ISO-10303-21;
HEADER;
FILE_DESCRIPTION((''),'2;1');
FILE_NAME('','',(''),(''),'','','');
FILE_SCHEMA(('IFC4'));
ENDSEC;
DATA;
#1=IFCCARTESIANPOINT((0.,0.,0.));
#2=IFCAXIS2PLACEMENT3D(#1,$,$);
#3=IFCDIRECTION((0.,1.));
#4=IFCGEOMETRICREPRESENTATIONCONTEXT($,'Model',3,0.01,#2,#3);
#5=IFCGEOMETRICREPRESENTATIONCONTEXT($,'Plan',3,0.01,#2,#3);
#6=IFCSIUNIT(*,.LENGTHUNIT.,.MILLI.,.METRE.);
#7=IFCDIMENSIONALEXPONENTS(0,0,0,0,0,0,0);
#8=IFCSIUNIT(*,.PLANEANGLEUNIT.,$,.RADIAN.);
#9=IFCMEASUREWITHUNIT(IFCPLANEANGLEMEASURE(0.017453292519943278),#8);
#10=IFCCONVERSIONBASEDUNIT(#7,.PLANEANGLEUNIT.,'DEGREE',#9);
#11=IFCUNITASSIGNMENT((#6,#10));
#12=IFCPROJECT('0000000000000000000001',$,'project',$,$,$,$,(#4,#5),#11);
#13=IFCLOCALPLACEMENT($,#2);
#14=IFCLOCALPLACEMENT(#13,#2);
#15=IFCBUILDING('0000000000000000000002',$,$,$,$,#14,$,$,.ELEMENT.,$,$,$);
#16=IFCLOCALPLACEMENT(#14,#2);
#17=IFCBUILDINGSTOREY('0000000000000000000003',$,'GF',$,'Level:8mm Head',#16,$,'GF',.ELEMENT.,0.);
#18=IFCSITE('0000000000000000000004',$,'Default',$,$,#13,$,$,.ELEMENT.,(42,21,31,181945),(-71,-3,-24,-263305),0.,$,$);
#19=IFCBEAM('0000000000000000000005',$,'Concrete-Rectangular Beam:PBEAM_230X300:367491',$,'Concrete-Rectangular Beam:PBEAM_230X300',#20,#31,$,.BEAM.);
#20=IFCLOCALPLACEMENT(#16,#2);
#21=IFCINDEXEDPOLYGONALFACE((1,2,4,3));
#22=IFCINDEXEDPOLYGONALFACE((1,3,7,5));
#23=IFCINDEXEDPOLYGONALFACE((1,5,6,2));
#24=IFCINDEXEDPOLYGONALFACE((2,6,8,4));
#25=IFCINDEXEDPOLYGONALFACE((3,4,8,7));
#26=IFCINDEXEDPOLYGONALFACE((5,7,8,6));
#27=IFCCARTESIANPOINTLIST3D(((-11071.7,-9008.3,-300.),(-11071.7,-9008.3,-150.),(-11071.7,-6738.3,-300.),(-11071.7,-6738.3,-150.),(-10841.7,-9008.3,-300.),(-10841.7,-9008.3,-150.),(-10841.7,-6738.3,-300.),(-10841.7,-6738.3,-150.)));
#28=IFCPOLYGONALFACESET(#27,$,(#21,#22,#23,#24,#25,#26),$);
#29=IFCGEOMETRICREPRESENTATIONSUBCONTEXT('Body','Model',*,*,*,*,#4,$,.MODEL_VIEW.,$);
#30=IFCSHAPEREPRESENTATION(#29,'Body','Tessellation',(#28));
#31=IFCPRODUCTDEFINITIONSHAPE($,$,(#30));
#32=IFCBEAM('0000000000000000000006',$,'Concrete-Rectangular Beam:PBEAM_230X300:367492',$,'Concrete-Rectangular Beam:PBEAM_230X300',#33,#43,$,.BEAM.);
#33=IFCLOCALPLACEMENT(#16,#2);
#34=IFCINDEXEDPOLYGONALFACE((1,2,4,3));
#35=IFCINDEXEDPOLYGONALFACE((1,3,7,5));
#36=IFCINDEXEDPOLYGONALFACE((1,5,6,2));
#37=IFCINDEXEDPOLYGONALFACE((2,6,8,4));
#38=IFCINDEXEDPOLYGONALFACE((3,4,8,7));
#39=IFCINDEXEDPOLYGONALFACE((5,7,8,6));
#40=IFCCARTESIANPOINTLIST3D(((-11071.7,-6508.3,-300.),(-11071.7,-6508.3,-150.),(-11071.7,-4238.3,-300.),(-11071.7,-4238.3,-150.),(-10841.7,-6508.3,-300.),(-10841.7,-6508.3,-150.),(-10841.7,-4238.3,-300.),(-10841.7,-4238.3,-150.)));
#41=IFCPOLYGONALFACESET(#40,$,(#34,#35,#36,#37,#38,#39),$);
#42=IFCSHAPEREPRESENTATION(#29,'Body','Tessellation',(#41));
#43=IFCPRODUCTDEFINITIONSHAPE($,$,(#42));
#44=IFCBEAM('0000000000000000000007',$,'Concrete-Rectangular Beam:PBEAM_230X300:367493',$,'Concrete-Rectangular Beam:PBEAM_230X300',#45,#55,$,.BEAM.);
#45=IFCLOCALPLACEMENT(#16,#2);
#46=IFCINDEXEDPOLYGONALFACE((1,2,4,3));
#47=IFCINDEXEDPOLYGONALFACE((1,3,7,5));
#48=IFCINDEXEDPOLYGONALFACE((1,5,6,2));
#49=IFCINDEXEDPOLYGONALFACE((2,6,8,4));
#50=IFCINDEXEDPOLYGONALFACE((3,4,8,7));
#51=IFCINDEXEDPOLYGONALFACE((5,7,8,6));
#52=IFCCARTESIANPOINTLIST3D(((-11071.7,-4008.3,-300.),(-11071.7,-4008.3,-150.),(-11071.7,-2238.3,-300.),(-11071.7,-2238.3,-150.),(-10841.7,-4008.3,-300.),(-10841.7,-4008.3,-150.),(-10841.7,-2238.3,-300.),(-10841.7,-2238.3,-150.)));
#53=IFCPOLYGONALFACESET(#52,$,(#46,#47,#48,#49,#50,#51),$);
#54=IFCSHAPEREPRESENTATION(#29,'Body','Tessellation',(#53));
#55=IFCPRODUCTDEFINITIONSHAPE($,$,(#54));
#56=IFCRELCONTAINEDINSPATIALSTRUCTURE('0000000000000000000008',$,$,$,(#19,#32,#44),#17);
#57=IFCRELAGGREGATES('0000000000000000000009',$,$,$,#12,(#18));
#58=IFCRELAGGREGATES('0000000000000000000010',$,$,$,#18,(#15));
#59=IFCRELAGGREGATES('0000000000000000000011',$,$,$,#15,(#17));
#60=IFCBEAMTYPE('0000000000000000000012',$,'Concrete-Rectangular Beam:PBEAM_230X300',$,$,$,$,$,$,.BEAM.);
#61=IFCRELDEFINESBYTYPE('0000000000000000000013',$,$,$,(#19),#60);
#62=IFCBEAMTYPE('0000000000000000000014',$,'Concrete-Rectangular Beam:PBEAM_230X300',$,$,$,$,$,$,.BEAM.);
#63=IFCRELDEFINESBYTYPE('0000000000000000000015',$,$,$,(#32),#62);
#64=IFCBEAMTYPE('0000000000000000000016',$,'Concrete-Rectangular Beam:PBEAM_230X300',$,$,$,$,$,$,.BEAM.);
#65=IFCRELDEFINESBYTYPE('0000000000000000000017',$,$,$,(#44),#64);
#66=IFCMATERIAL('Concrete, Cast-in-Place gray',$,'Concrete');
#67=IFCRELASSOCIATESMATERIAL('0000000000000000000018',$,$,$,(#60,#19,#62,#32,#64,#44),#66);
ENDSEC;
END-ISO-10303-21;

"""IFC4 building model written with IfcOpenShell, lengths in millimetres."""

from ifc_helpers import new_model, entity, si_unit, converted_unit, direction, frame, origin, place, context, subcontext, project, spatial, indexed_curve, outline, extrude, source, transform, mapped, material, type_object, type_shapes, element, save


model = new_model("IFC4")

# Units and contexts
model_context = context("Model", 3, precision=0.01, world=origin(), true_north=direction((0.0, 1.0)))
plan_context = context("Plan", 3, precision=0.01, world=origin(), true_north=direction((0.0, 1.0)))
body_context = subcontext(model_context, "Body", "Model", "MODEL_VIEW")
ifc_project = project(units=[si_unit("LENGTHUNIT", "METRE", prefix="MILLI"), converted_unit("PLANEANGLEUNIT", "DEGREE", entity("IfcPlaneAngleMeasure", 0.017453292519943278), si_unit("PLANEANGLEUNIT", "RADIAN"), dimensions=[0, 0, 0, 0, 0, 0, 0])], contexts=[model_context, plan_context])

# Site, building, storey
site_placement = place(None, origin())
site = spatial("IfcSite", under=ifc_project, at=site_placement, Name="Default", CompositionType="ELEMENT", RefLatitude=(42, 21, 31, 181945), RefLongitude=(-71, -3, -24, -263305), RefElevation=0.0)
building_placement = place(site_placement, origin())
building = spatial("IfcBuilding", under=site, at=building_placement, CompositionType="ELEMENT")
storey_placement = place(building_placement, origin())
storey = spatial("IfcBuildingStorey", under=building, at=storey_placement, Name="GF", ObjectType="Level:8mm Head", LongName="GF", CompositionType="ELEMENT", Elevation=0.0)

# Beams
ifc_material = material(Name="Concrete, Cast-in-Place gray", Category="Concrete")
beam_type_1 = type_object("IfcBeamType", Name="Concrete-Rectangular Beam:PBEAM_230X300", PredefinedType="BEAM", material=ifc_material)
shared_shape_1 = source(origin(), body_context, "Body", "SweptSolid", [
    extrude(outline(indexed_curve([(-115.0, -75.0), (115.0, -75.0), (115.0, 75.0), (-115.0, 75.0), (-115.0, -75.0)], self_intersect=False)), frame((-10956.7, -9008.3, -225.0), z_axis=(0.0, 1.0, 0.0), x_axis=(-1.0, 0.0, 0.0)), (0.0, 0.0, 1.0), 2270.0),
])
type_shapes(beam_type_1, [shared_shape_1])
beam_1_placement = place(storey_placement, origin())
element("IfcBeam", 1, at=beam_1_placement, inside=storey, type_object=beam_type_1, material=ifc_material, Name="Concrete-Rectangular Beam:PBEAM_230X300:367491", ObjectType="Concrete-Rectangular Beam:PBEAM_230X300", PredefinedType="BEAM", context=body_context, shape_type="MappedRepresentation", body=[
    mapped(shared_shape_1, transform((0.0, 0.0, 0.0), scale=1.0)),
])
beam_type_2 = type_object("IfcBeamType", Name="Concrete-Rectangular Beam:PBEAM_230X300", PredefinedType="BEAM", material=ifc_material)
shared_shape_2 = source(origin(), body_context, "Body", "SweptSolid", [
    extrude(outline(indexed_curve([(-115.0, -75.0), (115.0, -75.0), (115.0, 75.0), (-115.0, 75.0), (-115.0, -75.0)], self_intersect=False)), frame((-10956.7, -6508.3, -225.0), z_axis=(0.0, 1.0, 0.0), x_axis=(-1.0, 0.0, 0.0)), (0.0, 0.0, 1.0), 2270.0),
])
type_shapes(beam_type_2, [shared_shape_2])
beam_2_placement = place(storey_placement, origin())
element("IfcBeam", 2, at=beam_2_placement, inside=storey, type_object=beam_type_2, material=ifc_material, Name="Concrete-Rectangular Beam:PBEAM_230X300:367492", ObjectType="Concrete-Rectangular Beam:PBEAM_230X300", PredefinedType="BEAM", context=body_context, shape_type="MappedRepresentation", body=[
    mapped(shared_shape_2, transform((0.0, 0.0, 0.0), scale=1.0)),
])
beam_type_3 = type_object("IfcBeamType", Name="Concrete-Rectangular Beam:PBEAM_230X300", PredefinedType="BEAM", material=ifc_material)
shared_shape_3 = source(origin(), body_context, "Body", "SweptSolid", [
    extrude(outline(indexed_curve([(-115.0, -75.0), (115.0, -75.0), (115.0, 75.0), (-115.0, 75.0), (-115.0, -75.0)], self_intersect=False)), frame((-10956.7, -4008.3, -225.0), z_axis=(0.0, 1.0, 0.0), x_axis=(-1.0, 0.0, 0.0)), (0.0, 0.0, 1.0), 1770.0),
])
type_shapes(beam_type_3, [shared_shape_3])
beam_3_placement = place(storey_placement, origin())
element("IfcBeam", 3, at=beam_3_placement, inside=storey, type_object=beam_type_3, material=ifc_material, Name="Concrete-Rectangular Beam:PBEAM_230X300:367493", ObjectType="Concrete-Rectangular Beam:PBEAM_230X300", PredefinedType="BEAM", context=body_context, shape_type="MappedRepresentation", body=[
    mapped(shared_shape_3, transform((0.0, 0.0, 0.0), scale=1.0)),
])

save(model, "model.ifc")
